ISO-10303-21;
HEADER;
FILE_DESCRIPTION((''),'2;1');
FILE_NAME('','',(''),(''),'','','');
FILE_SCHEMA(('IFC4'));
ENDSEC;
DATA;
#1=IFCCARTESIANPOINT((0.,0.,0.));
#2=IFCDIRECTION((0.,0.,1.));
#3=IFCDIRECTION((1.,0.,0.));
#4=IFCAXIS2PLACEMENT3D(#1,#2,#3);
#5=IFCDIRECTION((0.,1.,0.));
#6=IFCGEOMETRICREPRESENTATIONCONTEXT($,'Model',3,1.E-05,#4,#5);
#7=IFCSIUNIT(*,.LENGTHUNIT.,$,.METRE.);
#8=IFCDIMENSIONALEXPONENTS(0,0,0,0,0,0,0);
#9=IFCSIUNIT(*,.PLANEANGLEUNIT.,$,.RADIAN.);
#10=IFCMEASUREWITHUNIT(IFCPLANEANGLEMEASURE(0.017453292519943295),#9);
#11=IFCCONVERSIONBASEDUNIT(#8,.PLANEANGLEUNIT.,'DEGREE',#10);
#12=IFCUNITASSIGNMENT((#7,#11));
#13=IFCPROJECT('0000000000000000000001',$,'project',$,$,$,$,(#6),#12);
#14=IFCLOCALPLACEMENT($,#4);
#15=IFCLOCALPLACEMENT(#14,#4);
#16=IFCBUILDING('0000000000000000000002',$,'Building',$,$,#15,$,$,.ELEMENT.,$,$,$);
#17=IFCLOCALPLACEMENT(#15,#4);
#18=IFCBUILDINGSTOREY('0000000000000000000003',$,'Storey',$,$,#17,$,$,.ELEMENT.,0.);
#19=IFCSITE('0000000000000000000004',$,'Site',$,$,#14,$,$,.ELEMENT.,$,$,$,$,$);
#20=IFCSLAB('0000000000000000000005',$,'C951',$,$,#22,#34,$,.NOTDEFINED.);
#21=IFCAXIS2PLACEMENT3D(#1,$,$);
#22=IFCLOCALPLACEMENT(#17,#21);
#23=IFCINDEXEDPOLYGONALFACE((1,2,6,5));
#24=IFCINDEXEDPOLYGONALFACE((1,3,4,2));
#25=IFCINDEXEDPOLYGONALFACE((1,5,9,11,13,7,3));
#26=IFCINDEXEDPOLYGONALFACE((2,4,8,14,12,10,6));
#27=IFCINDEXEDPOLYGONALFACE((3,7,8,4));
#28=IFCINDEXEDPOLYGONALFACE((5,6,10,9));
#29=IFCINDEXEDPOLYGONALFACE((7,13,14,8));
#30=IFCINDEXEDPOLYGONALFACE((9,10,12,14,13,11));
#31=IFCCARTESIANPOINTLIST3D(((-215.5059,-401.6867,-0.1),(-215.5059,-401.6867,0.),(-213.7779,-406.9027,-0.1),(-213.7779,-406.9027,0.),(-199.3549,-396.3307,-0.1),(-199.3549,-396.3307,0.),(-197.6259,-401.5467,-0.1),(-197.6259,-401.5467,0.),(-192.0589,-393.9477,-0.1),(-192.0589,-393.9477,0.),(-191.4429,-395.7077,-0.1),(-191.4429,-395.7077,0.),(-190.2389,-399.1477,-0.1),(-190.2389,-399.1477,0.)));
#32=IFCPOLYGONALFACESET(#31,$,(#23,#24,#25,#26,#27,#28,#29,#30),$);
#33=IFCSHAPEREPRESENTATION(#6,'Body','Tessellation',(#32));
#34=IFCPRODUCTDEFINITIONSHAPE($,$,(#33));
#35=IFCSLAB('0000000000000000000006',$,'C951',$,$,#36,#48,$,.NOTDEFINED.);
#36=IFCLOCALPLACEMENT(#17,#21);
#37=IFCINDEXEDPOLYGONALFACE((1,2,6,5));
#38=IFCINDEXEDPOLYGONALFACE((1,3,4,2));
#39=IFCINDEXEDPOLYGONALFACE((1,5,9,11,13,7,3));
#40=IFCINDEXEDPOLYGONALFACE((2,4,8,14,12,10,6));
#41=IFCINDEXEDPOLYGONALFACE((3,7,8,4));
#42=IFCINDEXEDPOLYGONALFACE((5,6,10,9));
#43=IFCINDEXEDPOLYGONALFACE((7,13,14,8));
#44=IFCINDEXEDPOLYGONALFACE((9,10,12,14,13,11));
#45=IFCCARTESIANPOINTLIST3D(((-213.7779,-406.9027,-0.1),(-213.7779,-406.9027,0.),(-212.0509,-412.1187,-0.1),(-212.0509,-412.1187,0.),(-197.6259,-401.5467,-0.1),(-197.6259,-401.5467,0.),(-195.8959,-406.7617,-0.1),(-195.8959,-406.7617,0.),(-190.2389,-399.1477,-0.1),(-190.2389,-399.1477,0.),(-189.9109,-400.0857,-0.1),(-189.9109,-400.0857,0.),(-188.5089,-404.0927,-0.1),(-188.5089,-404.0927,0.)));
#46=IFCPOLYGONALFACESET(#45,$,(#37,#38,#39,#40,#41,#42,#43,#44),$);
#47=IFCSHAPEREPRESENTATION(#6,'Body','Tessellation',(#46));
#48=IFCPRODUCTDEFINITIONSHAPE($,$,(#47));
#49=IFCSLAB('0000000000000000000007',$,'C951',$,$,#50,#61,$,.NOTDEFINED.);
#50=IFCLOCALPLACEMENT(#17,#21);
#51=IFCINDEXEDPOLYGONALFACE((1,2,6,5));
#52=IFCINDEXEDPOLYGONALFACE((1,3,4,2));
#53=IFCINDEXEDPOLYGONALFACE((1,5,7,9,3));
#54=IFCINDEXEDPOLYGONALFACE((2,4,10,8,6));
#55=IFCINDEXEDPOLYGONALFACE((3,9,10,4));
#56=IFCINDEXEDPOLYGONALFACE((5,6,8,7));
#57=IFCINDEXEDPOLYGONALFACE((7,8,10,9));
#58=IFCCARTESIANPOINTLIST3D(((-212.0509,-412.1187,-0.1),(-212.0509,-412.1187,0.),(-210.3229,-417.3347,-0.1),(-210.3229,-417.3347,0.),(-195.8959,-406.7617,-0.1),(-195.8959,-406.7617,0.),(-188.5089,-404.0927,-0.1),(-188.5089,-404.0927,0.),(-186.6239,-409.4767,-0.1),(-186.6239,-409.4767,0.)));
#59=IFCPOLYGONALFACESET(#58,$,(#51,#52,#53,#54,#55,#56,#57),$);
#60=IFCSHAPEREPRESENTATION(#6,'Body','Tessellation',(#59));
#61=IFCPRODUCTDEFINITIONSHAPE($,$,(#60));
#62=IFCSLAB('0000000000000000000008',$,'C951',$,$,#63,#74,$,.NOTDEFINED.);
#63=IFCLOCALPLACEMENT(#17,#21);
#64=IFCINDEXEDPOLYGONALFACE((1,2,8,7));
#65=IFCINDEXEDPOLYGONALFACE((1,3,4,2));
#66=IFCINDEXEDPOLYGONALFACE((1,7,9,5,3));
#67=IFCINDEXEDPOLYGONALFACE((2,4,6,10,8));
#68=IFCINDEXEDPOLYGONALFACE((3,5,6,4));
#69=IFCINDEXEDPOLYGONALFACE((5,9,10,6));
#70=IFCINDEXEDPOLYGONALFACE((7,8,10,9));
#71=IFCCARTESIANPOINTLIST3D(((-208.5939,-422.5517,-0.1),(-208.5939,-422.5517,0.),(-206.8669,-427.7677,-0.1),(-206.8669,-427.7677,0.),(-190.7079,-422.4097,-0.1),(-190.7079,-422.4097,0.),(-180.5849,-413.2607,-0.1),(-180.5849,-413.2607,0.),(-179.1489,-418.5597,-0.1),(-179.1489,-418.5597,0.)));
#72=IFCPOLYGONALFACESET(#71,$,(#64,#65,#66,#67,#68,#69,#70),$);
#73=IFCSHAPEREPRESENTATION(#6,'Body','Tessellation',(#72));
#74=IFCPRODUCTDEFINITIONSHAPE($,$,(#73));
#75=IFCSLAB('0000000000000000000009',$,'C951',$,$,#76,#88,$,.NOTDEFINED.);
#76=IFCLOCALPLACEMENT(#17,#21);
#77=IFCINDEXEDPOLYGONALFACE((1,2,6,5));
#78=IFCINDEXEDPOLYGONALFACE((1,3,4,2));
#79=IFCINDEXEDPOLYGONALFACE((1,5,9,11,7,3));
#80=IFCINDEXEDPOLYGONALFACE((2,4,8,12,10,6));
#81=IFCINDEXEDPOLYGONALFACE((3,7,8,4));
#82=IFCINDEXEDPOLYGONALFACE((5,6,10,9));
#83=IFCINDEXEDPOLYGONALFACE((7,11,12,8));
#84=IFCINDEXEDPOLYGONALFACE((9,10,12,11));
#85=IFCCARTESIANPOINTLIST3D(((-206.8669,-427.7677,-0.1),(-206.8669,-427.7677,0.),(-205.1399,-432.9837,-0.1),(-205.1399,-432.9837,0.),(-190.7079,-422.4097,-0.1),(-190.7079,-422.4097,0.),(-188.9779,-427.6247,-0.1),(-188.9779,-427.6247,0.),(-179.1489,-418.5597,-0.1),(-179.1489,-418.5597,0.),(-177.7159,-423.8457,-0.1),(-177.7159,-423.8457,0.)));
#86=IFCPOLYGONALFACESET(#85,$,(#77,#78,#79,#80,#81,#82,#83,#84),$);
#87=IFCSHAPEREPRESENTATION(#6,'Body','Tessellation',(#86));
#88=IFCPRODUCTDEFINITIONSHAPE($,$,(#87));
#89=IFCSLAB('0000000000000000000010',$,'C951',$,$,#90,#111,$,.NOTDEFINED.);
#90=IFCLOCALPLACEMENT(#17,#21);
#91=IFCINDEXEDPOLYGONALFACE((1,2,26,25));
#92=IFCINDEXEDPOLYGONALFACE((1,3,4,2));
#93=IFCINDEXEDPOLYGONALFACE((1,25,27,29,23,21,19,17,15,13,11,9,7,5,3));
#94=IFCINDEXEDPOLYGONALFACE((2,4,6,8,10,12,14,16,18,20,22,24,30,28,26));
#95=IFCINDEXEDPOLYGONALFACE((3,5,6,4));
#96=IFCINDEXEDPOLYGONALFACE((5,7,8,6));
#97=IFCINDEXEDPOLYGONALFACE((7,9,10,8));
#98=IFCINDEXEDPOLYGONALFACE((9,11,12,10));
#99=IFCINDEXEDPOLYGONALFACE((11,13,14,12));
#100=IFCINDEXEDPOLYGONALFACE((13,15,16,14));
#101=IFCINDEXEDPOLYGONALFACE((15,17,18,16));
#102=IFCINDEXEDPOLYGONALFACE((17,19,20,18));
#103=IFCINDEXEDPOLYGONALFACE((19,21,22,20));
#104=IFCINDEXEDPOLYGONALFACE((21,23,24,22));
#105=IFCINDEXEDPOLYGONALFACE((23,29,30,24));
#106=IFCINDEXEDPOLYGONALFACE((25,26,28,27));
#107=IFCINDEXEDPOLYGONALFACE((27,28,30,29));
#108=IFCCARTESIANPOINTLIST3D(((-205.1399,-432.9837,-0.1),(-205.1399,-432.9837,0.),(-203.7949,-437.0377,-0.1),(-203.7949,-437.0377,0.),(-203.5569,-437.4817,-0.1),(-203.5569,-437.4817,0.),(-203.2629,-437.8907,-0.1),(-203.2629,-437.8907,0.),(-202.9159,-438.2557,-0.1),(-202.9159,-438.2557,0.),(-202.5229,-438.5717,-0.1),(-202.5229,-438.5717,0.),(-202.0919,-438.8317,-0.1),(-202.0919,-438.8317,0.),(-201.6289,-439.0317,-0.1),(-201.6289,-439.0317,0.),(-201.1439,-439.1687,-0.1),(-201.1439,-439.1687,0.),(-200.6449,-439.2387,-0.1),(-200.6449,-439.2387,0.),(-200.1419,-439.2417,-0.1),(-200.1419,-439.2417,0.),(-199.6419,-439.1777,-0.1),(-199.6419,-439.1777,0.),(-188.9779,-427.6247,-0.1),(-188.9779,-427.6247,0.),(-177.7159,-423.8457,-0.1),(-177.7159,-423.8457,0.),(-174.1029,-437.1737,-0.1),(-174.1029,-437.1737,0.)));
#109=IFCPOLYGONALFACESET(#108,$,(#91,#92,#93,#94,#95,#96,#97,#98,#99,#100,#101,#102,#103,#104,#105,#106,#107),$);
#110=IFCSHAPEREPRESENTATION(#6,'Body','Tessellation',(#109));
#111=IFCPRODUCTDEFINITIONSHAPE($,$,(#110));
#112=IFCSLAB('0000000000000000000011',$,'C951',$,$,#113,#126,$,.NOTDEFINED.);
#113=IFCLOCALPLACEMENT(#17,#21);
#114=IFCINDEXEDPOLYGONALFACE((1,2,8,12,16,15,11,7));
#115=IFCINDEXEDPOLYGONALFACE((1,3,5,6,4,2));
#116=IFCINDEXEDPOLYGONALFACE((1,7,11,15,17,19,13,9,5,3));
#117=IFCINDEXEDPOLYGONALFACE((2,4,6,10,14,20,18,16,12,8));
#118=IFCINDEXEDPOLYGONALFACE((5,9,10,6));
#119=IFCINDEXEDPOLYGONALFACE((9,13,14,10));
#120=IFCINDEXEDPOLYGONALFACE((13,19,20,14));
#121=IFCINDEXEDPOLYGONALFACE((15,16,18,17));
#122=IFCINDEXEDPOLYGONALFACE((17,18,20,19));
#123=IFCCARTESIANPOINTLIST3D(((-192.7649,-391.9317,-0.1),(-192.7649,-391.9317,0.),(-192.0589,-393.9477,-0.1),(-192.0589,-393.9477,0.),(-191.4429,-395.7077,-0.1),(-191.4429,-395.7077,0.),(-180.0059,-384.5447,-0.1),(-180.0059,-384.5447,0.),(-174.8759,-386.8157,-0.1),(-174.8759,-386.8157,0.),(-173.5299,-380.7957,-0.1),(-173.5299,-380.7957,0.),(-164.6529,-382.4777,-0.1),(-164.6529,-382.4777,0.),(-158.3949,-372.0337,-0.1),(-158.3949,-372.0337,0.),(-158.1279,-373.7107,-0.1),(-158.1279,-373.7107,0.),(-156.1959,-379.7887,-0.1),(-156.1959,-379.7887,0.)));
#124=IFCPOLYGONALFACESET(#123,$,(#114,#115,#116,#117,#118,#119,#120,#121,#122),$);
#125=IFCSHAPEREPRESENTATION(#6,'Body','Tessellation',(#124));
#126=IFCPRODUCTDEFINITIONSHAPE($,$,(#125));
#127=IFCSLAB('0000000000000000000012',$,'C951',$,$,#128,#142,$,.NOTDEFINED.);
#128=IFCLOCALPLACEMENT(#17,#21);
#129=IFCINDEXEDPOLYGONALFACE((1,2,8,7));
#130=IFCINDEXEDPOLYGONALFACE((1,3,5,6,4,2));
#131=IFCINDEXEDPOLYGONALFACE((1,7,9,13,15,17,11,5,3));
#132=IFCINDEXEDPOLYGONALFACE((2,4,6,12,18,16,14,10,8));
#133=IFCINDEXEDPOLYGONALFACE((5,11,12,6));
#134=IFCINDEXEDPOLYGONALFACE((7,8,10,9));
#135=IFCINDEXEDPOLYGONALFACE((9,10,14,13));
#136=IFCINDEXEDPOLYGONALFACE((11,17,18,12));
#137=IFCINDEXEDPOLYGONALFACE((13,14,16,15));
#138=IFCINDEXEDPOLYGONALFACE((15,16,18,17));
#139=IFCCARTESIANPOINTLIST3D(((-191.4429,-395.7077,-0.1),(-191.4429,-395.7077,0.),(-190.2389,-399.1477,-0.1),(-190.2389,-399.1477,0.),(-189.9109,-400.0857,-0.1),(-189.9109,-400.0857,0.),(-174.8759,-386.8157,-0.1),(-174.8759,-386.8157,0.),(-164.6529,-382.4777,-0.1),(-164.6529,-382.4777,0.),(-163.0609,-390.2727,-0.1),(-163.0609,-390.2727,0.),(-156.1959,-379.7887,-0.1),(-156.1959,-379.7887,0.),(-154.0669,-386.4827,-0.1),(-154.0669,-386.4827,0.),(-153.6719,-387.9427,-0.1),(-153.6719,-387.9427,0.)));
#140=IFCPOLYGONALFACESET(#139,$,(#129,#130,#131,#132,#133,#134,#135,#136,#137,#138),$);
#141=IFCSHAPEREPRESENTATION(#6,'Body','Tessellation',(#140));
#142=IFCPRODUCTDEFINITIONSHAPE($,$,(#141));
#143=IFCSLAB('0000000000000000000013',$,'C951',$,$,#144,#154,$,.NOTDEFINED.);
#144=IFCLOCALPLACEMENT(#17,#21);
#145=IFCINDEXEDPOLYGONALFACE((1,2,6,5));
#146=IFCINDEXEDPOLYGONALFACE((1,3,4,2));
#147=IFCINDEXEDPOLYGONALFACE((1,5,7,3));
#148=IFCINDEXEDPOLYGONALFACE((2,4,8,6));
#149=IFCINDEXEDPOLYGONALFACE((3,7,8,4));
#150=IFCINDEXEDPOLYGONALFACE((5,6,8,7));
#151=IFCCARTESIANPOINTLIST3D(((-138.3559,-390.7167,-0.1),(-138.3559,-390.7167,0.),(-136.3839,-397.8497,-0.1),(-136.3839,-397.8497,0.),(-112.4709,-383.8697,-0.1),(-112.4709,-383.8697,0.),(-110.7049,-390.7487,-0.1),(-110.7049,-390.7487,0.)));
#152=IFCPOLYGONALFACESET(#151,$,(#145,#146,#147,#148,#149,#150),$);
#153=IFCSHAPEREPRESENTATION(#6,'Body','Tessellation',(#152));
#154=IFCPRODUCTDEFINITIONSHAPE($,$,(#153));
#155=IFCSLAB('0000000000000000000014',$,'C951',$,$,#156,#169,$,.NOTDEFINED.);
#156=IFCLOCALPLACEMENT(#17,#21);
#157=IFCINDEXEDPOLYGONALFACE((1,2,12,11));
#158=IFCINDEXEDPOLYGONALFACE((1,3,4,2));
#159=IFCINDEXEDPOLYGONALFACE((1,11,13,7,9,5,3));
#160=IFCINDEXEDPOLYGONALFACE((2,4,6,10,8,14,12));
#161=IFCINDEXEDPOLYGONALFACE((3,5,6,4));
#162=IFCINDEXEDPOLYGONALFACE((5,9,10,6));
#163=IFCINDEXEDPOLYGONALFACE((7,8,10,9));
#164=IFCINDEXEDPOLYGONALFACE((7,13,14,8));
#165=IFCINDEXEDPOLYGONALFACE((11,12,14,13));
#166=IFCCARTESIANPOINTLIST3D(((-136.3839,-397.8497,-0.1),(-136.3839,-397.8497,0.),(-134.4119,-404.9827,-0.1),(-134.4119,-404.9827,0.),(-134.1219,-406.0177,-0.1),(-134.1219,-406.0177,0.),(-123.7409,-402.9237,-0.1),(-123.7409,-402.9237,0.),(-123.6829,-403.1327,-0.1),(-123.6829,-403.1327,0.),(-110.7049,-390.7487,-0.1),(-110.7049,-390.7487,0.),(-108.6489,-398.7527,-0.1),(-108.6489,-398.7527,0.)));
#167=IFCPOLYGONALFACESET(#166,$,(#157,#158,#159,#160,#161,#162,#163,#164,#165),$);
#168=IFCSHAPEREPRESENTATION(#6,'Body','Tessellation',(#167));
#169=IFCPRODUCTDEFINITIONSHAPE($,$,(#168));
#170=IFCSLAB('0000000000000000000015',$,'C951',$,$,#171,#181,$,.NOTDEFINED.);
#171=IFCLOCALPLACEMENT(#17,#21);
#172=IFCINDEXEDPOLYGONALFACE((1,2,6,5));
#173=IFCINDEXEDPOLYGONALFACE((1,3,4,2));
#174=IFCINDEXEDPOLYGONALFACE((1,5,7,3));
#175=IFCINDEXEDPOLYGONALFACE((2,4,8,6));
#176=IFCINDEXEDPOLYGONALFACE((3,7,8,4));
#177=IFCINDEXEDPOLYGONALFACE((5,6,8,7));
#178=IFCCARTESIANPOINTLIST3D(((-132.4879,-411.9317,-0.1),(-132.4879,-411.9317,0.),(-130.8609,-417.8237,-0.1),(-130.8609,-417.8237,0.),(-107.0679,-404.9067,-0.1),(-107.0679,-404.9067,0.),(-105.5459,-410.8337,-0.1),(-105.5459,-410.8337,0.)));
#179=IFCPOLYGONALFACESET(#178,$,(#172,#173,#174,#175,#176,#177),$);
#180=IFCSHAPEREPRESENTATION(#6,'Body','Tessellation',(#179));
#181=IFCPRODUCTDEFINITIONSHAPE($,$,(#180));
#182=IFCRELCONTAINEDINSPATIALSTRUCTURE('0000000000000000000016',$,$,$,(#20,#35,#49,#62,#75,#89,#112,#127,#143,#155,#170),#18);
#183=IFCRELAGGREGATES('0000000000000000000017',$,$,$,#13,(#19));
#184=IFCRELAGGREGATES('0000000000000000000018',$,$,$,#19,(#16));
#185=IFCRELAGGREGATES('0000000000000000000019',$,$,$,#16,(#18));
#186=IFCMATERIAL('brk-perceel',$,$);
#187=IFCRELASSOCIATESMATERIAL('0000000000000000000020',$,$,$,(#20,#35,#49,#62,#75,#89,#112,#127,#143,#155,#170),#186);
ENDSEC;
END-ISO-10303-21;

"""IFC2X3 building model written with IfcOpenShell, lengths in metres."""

from ifc_helpers import new_model, entity, si_unit, converted_unit, direction, frame, origin_with_axes, place, context, project, spatial, polyline, outline, extrude, material, element, save


model = new_model("IFC2X3")

# Units and contexts
model_context = context("Model", 3, precision=1e-05, world=origin_with_axes(), true_north=direction((0.0, 1.0, 0.0)))
ifc_project = project(units=[si_unit("LENGTHUNIT", "METRE"), converted_unit("PLANEANGLEUNIT", "DEGREE", entity("IfcPlaneAngleMeasure", 0.017453292519943295), si_unit("PLANEANGLEUNIT", "RADIAN"), dimensions=[0, 0, 0, 0, 0, 0, 0])], contexts=[model_context])

# Site, building, storey
site_placement = place(None, origin_with_axes())
site = spatial("IfcSite", under=ifc_project, at=site_placement, Name="Site", CompositionType="ELEMENT")
building_placement = place(site_placement, origin_with_axes())
building = spatial("IfcBuilding", under=site, at=building_placement, Name="Building", CompositionType="ELEMENT")
storey_placement = place(building_placement, origin_with_axes())
storey = spatial("IfcBuildingStorey", under=building, at=storey_placement, Name="Storey", CompositionType="ELEMENT", Elevation=0.0)

# Slabs
ifc_material = material(Name="brk-perceel")
slab_1_placement = place(storey_placement, frame((0.0, 0.0, -0.1), z_axis=(0.0, 0.0, 1.0), x_axis=(1.0, 0.0, 0.0)))
element("IfcSlab", 1, at=slab_1_placement, inside=storey, material=ifc_material, Name="C951", PredefinedType="NOTDEFINED", context=model_context, shape_type="SweptSolid", body=[
    extrude(outline(polyline([(-199.3549, -396.3307), (-192.0589, -393.9477), (-191.4429, -395.7077), (-190.2389, -399.1477), (-197.6259, -401.5467), (-213.7779, -406.9027), (-215.5059, -401.6867), (-199.3549, -396.3307)])), origin_with_axes(), (0.0, 0.0, 1.0), 0.1),
])
slab_2_placement = place(storey_placement, frame((0.0, 0.0, -0.1), z_axis=(0.0, 0.0, 1.0), x_axis=(1.0, 0.0, 0.0)))
element("IfcSlab", 2, at=slab_2_placement, inside=storey, material=ifc_material, Name="C951", PredefinedType="NOTDEFINED", context=model_context, shape_type="SweptSolid", body=[
    extrude(outline(polyline([(-197.6259, -401.5467), (-190.2389, -399.1477), (-189.9109, -400.0857), (-188.5089, -404.0927), (-195.8959, -406.7617), (-212.0509, -412.1187), (-213.7779, -406.9027), (-197.6259, -401.5467)])), origin_with_axes(), (0.0, 0.0, 1.0), 0.1),
])
slab_3_placement = place(storey_placement, frame((0.0, 0.0, -0.1), z_axis=(0.0, 0.0, 1.0), x_axis=(1.0, 0.0, 0.0)))
element("IfcSlab", 3, at=slab_3_placement, inside=storey, material=ifc_material, Name="C951", PredefinedType="NOTDEFINED", context=model_context, shape_type="SweptSolid", body=[
    extrude(outline(polyline([(-210.3229, -417.3347), (-212.0509, -412.1187), (-195.8959, -406.7617), (-188.5089, -404.0927), (-186.6239, -409.4767), (-210.3229, -417.3347)])), origin_with_axes(), (0.0, 0.0, 1.0), 0.1),
])
slab_4_placement = place(storey_placement, frame((0.0, 0.0, -0.1), z_axis=(0.0, 0.0, 1.0), x_axis=(1.0, 0.0, 0.0)))
element("IfcSlab", 4, at=slab_4_placement, inside=storey, material=ifc_material, Name="C951", PredefinedType="NOTDEFINED", context=model_context, shape_type="SweptSolid", body=[
    extrude(outline(polyline([(-190.7079, -422.4097), (-206.8669, -427.7677), (-208.5939, -422.5517), (-180.5849, -413.2607), (-179.1489, -418.5597), (-190.7079, -422.4097)])), origin_with_axes(), (0.0, 0.0, 1.0), 0.1),
])
slab_5_placement = place(storey_placement, frame((0.0, 0.0, -0.1), z_axis=(0.0, 0.0, 1.0), x_axis=(1.0, 0.0, 0.0)))
element("IfcSlab", 5, at=slab_5_placement, inside=storey, material=ifc_material, Name="C951", PredefinedType="NOTDEFINED", context=model_context, shape_type="SweptSolid", body=[
    extrude(outline(polyline([(-177.7159, -423.8457), (-188.9779, -427.6247), (-205.1399, -432.9837), (-206.8669, -427.7677), (-190.7079, -422.4097), (-179.1489, -418.5597), (-177.7159, -423.8457)])), origin_with_axes(), (0.0, 0.0, 1.0), 0.1),
])
slab_6_placement = place(storey_placement, frame((0.0, 0.0, -0.1), z_axis=(0.0, 0.0, 1.0), x_axis=(1.0, 0.0, 0.0)))
element("IfcSlab", 6, at=slab_6_placement, inside=storey, material=ifc_material, Name="C951", PredefinedType="NOTDEFINED", context=model_context, shape_type="SweptSolid", body=[
    extrude(outline(polyline([(-188.9779, -427.6247), (-177.7159, -423.8457), (-174.1029, -437.1737), (-199.6419, -439.1777), (-200.1419, -439.2417), (-200.6449, -439.2387), (-201.1439, -439.1687), (-201.6289, -439.0317), (-202.0919, -438.8317), (-202.5229, -438.5717), (-202.9159, -438.2557), (-203.2629, -437.8907), (-203.5569, -437.4817), (-203.7949, -437.0377), (-205.1399, -432.9837), (-188.9779, -427.6247)])), origin_with_axes(), (0.0, 0.0, 1.0), 0.1),
])
slab_7_placement = place(storey_placement, frame((0.0, 0.0, -0.1), z_axis=(0.0, 0.0, 1.0), x_axis=(1.0, 0.0, 0.0)))
element("IfcSlab", 7, at=slab_7_placement, inside=storey, material=ifc_material, Name="C951", PredefinedType="NOTDEFINED", context=model_context, shape_type="SweptSolid", body=[
    extrude(outline(polyline([(-180.0059, -384.5447), (-173.5299, -380.7957), (-158.3949, -372.0337), (-158.1279, -373.7107), (-156.1959, -379.7887), (-164.6529, -382.4777), (-174.8759, -386.8157), (-191.4429, -395.7077), (-192.0589, -393.9477), (-192.7649, -391.9317), (-180.0059, -384.5447)])), origin_with_axes(), (0.0, 0.0, 1.0), 0.1),
])
slab_8_placement = place(storey_placement, frame((0.0, 0.0, -0.1), z_axis=(0.0, 0.0, 1.0), x_axis=(1.0, 0.0, 0.0)))
element("IfcSlab", 8, at=slab_8_placement, inside=storey, material=ifc_material, Name="C951", PredefinedType="NOTDEFINED", context=model_context, shape_type="SweptSolid", body=[
    extrude(outline(polyline([(-174.8759, -386.8157), (-164.6529, -382.4777), (-156.1959, -379.7887), (-154.0669, -386.4827), (-153.6719, -387.9427), (-163.0609, -390.2727), (-189.9109, -400.0857), (-190.2389, -399.1477), (-191.4429, -395.7077), (-174.8759, -386.8157)])), origin_with_axes(), (0.0, 0.0, 1.0), 0.1),
])
slab_9_placement = place(storey_placement, frame((0.0, 0.0, -0.1), z_axis=(0.0, 0.0, 1.0), x_axis=(1.0, 0.0, 0.0)))
element("IfcSlab", 9, at=slab_9_placement, inside=storey, material=ifc_material, Name="C951", PredefinedType="NOTDEFINED", context=model_context, shape_type="SweptSolid", body=[
    extrude(outline(polyline([(-112.4709, -383.8697), (-110.7049, -390.7487), (-136.3839, -397.8497), (-138.3559, -390.7167), (-112.4709, -383.8697)])), origin_with_axes(), (0.0, 0.0, 1.0), 0.1),
])
slab_10_placement = place(storey_placement, frame((0.0, 0.0, -0.1), z_axis=(0.0, 0.0, 1.0), x_axis=(1.0, 0.0, 0.0)))
element("IfcSlab", 10, at=slab_10_placement, inside=storey, material=ifc_material, Name="C951", PredefinedType="NOTDEFINED", context=model_context, shape_type="SweptSolid", body=[
    extrude(outline(polyline([(-123.7409, -402.9237), (-123.6829, -403.1327), (-134.1219, -406.0177), (-134.4119, -404.9827), (-136.3839, -397.8497), (-110.7049, -390.7487), (-108.6489, -398.7527), (-123.7409, -402.9237)])), origin_with_axes(), (0.0, 0.0, 1.0), 0.1),
])
slab_11_placement = place(storey_placement, frame((0.0, 0.0, -0.1), z_axis=(0.0, 0.0, 1.0), x_axis=(1.0, 0.0, 0.0)))
element("IfcSlab", 11, at=slab_11_placement, inside=storey, material=ifc_material, Name="C951", PredefinedType="NOTDEFINED", context=model_context, shape_type="SweptSolid", body=[
    extrude(outline(polyline([(-130.8609, -417.8237), (-132.4879, -411.9317), (-107.0679, -404.9067), (-105.5459, -410.8337), (-130.8609, -417.8237)])), origin_with_axes(), (0.0, 0.0, 1.0), 0.1),
])

save(model, "model.ifc")
